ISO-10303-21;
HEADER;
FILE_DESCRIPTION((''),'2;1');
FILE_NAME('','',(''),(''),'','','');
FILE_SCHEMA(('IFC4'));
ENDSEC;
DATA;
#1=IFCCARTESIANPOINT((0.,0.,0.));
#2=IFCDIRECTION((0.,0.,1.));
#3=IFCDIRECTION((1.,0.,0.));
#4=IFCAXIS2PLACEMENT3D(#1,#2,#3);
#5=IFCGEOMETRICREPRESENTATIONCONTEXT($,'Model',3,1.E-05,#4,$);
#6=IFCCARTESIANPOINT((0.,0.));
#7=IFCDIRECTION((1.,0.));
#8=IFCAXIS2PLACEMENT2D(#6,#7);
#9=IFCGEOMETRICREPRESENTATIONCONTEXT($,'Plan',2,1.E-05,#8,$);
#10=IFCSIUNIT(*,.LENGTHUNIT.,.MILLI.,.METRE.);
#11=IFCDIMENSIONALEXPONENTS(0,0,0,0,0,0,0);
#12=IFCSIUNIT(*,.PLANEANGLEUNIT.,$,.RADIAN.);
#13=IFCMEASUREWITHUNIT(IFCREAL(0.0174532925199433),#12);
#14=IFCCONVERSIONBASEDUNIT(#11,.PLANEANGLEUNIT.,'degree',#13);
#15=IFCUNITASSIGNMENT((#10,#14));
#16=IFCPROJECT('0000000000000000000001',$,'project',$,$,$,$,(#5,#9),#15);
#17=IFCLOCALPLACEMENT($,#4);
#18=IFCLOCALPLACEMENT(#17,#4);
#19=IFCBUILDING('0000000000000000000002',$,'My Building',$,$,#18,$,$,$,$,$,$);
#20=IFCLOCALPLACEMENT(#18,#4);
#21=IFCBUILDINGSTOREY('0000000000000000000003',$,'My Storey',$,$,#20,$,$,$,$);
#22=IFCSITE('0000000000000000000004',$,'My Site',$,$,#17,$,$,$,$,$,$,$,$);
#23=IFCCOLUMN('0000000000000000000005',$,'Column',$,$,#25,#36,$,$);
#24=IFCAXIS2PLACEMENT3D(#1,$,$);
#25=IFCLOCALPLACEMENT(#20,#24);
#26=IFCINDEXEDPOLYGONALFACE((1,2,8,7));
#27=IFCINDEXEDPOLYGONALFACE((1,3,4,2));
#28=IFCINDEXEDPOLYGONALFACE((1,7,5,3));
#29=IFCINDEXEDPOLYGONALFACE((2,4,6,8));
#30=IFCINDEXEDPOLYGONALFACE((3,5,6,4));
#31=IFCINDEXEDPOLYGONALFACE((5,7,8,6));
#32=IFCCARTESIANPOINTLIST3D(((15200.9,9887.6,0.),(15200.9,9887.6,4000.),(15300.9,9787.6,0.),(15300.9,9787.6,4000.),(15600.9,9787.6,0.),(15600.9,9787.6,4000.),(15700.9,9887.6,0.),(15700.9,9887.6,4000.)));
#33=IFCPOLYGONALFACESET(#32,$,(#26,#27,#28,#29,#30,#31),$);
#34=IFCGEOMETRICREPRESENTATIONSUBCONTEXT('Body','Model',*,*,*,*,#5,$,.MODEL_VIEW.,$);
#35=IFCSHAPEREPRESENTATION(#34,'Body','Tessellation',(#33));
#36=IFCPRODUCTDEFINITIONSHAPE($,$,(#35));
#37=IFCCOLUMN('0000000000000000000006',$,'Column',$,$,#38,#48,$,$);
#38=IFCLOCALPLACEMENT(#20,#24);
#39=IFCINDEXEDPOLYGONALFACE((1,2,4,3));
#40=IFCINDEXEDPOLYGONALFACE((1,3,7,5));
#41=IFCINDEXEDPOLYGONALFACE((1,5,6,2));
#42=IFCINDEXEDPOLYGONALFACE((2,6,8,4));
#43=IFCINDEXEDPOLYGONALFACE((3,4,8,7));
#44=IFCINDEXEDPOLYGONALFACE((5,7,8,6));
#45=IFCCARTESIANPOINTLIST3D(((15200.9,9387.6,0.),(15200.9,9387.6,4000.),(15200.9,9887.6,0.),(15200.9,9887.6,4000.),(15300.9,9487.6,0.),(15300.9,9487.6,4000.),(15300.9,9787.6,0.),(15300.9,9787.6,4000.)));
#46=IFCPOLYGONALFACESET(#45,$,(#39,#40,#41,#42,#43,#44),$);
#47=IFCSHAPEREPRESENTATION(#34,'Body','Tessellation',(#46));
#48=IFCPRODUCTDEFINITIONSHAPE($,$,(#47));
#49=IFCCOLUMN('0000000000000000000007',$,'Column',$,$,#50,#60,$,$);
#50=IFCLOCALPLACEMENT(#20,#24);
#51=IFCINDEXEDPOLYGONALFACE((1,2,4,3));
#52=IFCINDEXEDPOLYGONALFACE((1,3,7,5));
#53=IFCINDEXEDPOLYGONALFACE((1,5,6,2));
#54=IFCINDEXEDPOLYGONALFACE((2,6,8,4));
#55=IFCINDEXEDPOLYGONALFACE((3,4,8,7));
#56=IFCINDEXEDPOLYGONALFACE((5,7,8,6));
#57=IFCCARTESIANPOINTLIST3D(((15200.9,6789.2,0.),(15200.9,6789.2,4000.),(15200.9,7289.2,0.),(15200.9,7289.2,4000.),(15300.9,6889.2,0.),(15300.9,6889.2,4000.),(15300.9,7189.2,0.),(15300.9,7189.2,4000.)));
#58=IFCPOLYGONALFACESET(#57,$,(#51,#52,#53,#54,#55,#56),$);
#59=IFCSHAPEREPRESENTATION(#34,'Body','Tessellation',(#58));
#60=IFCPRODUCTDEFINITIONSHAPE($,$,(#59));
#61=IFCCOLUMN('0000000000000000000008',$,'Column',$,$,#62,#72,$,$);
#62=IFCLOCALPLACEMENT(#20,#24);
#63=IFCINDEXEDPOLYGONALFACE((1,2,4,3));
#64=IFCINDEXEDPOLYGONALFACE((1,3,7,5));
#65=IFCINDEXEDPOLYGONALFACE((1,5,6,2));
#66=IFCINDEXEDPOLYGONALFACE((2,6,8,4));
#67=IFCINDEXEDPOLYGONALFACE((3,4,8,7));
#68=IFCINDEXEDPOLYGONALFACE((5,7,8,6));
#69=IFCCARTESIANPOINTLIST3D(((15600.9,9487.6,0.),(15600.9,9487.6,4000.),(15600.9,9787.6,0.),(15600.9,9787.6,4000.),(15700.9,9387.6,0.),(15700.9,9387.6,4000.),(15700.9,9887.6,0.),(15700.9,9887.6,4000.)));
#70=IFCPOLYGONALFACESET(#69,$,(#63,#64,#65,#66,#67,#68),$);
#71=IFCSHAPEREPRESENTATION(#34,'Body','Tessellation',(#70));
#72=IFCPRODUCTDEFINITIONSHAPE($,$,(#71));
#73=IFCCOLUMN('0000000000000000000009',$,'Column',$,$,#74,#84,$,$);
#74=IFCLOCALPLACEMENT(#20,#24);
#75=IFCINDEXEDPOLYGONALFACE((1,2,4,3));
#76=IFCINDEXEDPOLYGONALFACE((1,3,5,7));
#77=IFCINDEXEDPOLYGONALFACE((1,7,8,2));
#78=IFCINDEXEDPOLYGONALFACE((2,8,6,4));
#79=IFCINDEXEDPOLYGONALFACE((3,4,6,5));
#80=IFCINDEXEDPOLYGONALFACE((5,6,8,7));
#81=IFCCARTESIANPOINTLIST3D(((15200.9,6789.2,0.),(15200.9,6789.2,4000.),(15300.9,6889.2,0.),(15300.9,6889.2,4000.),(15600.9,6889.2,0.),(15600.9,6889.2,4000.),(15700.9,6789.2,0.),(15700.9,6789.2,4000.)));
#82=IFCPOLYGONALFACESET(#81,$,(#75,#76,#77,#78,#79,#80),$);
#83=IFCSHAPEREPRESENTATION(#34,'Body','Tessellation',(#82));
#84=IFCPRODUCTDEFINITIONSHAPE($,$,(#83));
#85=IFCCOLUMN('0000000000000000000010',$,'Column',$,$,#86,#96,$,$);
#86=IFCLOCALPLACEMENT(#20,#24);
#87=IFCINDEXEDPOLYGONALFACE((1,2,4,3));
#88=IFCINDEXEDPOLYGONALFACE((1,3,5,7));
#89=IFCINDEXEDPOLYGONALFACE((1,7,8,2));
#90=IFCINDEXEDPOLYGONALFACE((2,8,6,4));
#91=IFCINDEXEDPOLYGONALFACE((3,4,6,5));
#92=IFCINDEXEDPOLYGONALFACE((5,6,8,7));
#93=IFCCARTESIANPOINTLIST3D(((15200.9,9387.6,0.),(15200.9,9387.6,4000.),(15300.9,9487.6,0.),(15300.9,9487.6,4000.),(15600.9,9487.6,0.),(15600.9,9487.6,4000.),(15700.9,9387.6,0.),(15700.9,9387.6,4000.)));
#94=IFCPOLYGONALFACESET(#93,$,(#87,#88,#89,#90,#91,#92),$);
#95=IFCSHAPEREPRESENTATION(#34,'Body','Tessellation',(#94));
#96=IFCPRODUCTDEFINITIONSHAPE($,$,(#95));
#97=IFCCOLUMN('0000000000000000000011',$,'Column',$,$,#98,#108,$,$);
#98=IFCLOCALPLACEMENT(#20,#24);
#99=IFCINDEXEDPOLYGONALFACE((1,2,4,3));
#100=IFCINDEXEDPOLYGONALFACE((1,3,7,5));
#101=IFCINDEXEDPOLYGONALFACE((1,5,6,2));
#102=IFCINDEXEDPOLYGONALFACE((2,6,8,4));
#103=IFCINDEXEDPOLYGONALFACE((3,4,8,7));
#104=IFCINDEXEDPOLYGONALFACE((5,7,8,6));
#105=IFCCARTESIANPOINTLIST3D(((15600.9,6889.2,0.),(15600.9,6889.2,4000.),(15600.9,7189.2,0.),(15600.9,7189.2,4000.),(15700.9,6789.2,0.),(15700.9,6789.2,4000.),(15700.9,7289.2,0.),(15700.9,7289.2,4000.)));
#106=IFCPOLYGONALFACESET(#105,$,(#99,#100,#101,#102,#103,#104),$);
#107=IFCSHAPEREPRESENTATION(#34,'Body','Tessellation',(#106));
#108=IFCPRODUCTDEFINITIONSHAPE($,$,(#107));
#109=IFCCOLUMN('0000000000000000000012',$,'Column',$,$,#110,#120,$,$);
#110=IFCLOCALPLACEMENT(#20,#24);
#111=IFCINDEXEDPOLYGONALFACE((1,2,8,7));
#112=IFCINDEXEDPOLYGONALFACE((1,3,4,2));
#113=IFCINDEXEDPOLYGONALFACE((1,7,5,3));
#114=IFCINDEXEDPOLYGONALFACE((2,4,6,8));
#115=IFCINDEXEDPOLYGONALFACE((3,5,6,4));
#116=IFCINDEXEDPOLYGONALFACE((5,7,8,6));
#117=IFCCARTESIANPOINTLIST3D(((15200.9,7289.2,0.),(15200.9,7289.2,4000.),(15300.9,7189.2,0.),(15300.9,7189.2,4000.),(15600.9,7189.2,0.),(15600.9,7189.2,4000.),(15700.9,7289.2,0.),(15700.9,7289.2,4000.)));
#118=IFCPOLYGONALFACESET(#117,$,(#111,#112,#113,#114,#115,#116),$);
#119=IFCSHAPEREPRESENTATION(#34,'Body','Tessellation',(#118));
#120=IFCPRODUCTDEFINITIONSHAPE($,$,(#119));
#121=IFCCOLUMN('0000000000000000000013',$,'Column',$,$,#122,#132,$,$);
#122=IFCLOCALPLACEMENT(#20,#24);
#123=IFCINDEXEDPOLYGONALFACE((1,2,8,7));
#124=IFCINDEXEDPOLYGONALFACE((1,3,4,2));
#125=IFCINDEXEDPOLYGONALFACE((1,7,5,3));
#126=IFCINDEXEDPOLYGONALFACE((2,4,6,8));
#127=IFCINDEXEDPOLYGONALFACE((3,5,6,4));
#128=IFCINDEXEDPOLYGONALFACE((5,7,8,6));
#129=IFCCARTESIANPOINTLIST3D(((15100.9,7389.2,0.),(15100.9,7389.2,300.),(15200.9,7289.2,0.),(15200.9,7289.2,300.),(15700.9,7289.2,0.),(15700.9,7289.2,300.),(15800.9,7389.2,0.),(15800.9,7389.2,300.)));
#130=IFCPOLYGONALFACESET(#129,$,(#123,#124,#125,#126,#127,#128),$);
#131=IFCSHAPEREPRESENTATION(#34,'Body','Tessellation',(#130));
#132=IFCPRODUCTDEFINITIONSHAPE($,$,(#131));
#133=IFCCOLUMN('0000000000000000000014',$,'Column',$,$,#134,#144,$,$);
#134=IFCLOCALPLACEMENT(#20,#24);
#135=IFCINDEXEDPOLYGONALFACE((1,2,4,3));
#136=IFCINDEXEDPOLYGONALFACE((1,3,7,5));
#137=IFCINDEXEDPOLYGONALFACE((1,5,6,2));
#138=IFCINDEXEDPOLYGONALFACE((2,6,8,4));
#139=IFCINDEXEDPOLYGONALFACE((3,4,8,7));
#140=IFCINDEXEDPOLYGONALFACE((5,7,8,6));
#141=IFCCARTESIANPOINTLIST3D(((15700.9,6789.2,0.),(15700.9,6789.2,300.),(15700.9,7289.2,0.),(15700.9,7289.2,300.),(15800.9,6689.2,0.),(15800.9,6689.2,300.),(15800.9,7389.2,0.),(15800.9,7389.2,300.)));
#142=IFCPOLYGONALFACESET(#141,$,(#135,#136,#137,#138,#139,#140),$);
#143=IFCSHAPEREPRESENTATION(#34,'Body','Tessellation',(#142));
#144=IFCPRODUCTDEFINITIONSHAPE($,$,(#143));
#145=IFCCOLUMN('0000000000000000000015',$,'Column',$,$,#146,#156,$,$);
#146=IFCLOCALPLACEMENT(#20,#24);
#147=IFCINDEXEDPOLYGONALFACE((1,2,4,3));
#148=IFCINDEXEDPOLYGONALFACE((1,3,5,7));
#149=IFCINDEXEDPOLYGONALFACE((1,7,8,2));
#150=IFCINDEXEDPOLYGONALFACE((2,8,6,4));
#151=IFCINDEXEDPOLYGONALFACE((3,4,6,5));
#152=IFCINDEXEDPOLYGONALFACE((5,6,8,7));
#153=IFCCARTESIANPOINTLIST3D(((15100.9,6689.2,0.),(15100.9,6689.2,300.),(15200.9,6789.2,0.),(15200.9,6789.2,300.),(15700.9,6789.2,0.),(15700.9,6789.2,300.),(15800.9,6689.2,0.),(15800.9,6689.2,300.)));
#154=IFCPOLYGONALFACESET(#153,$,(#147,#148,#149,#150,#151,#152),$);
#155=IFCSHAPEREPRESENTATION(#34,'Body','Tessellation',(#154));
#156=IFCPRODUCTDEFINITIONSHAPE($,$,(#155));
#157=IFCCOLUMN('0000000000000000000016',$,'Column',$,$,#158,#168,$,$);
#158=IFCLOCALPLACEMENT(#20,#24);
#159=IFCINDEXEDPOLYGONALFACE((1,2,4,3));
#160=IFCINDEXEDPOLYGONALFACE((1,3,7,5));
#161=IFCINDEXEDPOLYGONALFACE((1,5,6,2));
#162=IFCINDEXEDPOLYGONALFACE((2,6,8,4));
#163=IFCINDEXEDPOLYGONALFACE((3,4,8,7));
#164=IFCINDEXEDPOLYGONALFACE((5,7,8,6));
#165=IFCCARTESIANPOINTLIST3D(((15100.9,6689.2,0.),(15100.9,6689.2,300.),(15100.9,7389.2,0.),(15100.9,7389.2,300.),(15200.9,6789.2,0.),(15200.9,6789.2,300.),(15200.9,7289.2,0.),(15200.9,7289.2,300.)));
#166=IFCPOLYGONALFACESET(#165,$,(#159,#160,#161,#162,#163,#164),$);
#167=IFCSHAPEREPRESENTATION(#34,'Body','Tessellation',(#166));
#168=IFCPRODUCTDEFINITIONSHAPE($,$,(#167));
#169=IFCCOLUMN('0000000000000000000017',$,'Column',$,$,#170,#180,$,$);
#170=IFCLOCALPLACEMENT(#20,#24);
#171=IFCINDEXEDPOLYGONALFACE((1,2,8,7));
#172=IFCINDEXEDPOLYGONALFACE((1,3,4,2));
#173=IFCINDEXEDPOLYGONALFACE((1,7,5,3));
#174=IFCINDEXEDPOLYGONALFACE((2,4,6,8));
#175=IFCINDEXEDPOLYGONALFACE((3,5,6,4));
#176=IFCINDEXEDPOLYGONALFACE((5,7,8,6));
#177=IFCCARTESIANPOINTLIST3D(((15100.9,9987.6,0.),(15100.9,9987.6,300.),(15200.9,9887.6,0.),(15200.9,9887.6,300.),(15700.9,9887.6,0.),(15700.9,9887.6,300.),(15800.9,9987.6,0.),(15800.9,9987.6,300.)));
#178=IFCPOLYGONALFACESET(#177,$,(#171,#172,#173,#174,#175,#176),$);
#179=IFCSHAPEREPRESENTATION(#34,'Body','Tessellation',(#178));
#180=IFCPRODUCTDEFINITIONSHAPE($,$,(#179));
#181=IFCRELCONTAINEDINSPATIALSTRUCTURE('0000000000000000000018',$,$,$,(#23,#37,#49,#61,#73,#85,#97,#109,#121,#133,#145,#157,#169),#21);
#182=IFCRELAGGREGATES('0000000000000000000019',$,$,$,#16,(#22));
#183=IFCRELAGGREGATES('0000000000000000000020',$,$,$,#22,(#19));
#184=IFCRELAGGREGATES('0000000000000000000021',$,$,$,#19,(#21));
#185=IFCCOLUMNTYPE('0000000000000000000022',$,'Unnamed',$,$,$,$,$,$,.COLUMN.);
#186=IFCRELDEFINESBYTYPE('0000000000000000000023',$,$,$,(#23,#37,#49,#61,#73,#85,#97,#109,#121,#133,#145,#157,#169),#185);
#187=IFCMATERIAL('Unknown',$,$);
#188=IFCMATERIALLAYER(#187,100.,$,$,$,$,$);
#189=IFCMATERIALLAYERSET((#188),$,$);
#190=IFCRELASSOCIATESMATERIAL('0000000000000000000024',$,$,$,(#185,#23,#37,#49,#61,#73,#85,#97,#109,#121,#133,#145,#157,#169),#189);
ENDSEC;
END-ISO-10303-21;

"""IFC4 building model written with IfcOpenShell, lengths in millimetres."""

from ifc_helpers import new_model, entity, si_unit, converted_unit, frame, origin_with_axes, origin_2d_with_axis, place, context, subcontext, project, spatial, line, indexed_curve, outline, extrude, material, layer, layer_set, layer_usage, type_object, element, save


model = new_model("IFC4")

# Units and contexts
model_context = context("Model", 3, precision=1e-05, world=origin_with_axes())
plan_context = context("Plan", 2, precision=1e-05, world=origin_2d_with_axis())
body_context = subcontext(model_context, "Body", "Model", "MODEL_VIEW")
ifc_project = project(units=[si_unit("LENGTHUNIT", "METRE", prefix="MILLI"), converted_unit("PLANEANGLEUNIT", "degree", entity("IfcReal", 0.0174532925199433), si_unit("PLANEANGLEUNIT", "RADIAN"), dimensions=[0, 0, 0, 0, 0, 0, 0])], contexts=[model_context, plan_context])

# Site, building, storey
site_placement = place(None, origin_with_axes())
site = spatial("IfcSite", under=ifc_project, at=site_placement, Name="My Site")
building_placement = place(site_placement, origin_with_axes())
building = spatial("IfcBuilding", under=site, at=building_placement, Name="My Building")
storey_placement = place(building_placement, origin_with_axes())
storey = spatial("IfcBuildingStorey", under=building, at=storey_placement, Name="My Storey")

# Columns
ifc_material = material(Name="Unknown")
ifc_layer_1 = layer(ifc_material, 100.0)
ifc_layer_set_1 = layer_set([ifc_layer_1])
ifc_layer_usage_1 = layer_usage(ifc_layer_set_1, "AXIS2", "POSITIVE", 0.0)
column_type = type_object("IfcColumnType", Name="Unnamed", PredefinedType="COLUMN", material=ifc_layer_set_1)
column_1_placement = place(storey_placement, frame((15300.9, 9787.6, 0.0), z_axis=(0.0, 0.0, 1.0), x_axis=(1.0, 0.0, 0.0)))
element("IfcColumn", 1, at=column_1_placement, inside=storey, type_object=column_type, material=ifc_layer_usage_1, Name="Column", context=body_context, shape_type="SweptSolid", body=[
    extrude(outline(indexed_curve([(0.0, 0.0), (-100.0, 100.0), (400.0, 100.0), (300.0, 0.0)], segments=[line(1, 2, 3, 4, 1)])), origin_with_axes(), (0.0, 0.0, 1.0), 4000.0),
])
ifc_layer_usage_2 = layer_usage(ifc_layer_set_1, "AXIS2", "POSITIVE", 0.0)
column_2_placement = place(storey_placement, frame((15300.9, 9487.6, 0.0), z_axis=(0.0, 0.0, 1.0), x_axis=(0.0, 1.0, 0.0)))
element("IfcColumn", 2, at=column_2_placement, inside=storey, type_object=column_type, material=ifc_layer_usage_2, Name="Column", context=body_context, shape_type="SweptSolid", body=[
    extrude(outline(indexed_curve([(0.0, 0.0), (-100.0, 100.0), (400.0, 100.0), (300.0, 0.0)], segments=[line(1, 2, 3, 4, 1)])), origin_with_axes(), (0.0, 0.0, 1.0), 4000.0),
])
ifc_layer_usage_3 = layer_usage(ifc_layer_set_1, "AXIS2", "POSITIVE", 0.0)
column_3_placement = place(storey_placement, frame((15300.9, 6889.2, 0.0), z_axis=(0.0, 0.0, 1.0), x_axis=(0.0, 1.0, 0.0)))
element("IfcColumn", 3, at=column_3_placement, inside=storey, type_object=column_type, material=ifc_layer_usage_3, Name="Column", context=body_context, shape_type="SweptSolid", body=[
    extrude(outline(indexed_curve([(0.0, 0.0), (-100.0, 100.0), (400.0, 100.0), (300.0, 0.0)], segments=[line(1, 2, 3, 4, 1)])), origin_with_axes(), (0.0, 0.0, 1.0), 4000.0),
])
ifc_layer_usage_4 = layer_usage(ifc_layer_set_1, "AXIS2", "POSITIVE", 0.0)
column_4_placement = place(storey_placement, frame((15600.9, 9787.6, 0.0), z_axis=(0.0, 0.0, 1.0), x_axis=(0.0, -1.0, 0.0)))
element("IfcColumn", 4, at=column_4_placement, inside=storey, type_object=column_type, material=ifc_layer_usage_4, Name="Column", context=body_context, shape_type="SweptSolid", body=[
    extrude(outline(indexed_curve([(0.0, 0.0), (-100.0, 100.0), (400.0, 100.0), (300.0, 0.0)], segments=[line(1, 2, 3, 4, 1)])), origin_with_axes(), (0.0, 0.0, 1.0), 4000.0),
])
ifc_layer_usage_5 = layer_usage(ifc_layer_set_1, "AXIS2", "POSITIVE", 0.0)
column_5_placement = place(storey_placement, frame((15600.9, 6889.2, 0.0), z_axis=(0.0, 0.0, 1.0), x_axis=(-1.0, 0.0, 0.0)))
element("IfcColumn", 5, at=column_5_placement, inside=storey, type_object=column_type, material=ifc_layer_usage_5, Name="Column", context=body_context, shape_type="SweptSolid", body=[
    extrude(outline(indexed_curve([(0.0, 0.0), (-100.0, 100.0), (400.0, 100.0), (300.0, 0.0)], segments=[line(1, 2, 3, 4, 1)])), origin_with_axes(), (0.0, 0.0, 1.0), 4000.0),
])
ifc_layer_usage_6 = layer_usage(ifc_layer_set_1, "AXIS2", "POSITIVE", 0.0)
column_6_placement = place(storey_placement, frame((15600.9, 9487.6, 0.0), z_axis=(0.0, 0.0, 1.0), x_axis=(-1.0, 0.0, 0.0)))
element("IfcColumn", 6, at=column_6_placement, inside=storey, type_object=column_type, material=ifc_layer_usage_6, Name="Column", context=body_context, shape_type="SweptSolid", body=[
    extrude(outline(indexed_curve([(0.0, 0.0), (-100.0, 100.0), (400.0, 100.0), (300.0, 0.0)], segments=[line(1, 2, 3, 4, 1)])), origin_with_axes(), (0.0, 0.0, 1.0), 4000.0),
])
ifc_layer_usage_7 = layer_usage(ifc_layer_set_1, "AXIS2", "POSITIVE", 0.0)
column_7_placement = place(storey_placement, frame((15600.9, 7189.2, 0.0), z_axis=(0.0, 0.0, 1.0), x_axis=(0.0, -1.0, 0.0)))
element("IfcColumn", 7, at=column_7_placement, inside=storey, type_object=column_type, material=ifc_layer_usage_7, Name="Column", context=body_context, shape_type="SweptSolid", body=[
    extrude(outline(indexed_curve([(0.0, 0.0), (-100.0, 100.0), (400.0, 100.0), (300.0, 0.0)], segments=[line(1, 2, 3, 4, 1)])), origin_with_axes(), (0.0, 0.0, 1.0), 4000.0),
])
ifc_layer_usage_8 = layer_usage(ifc_layer_set_1, "AXIS2", "POSITIVE", 0.0)
column_8_placement = place(storey_placement, frame((15300.9, 7189.2, 0.0), z_axis=(0.0, 0.0, 1.0), x_axis=(1.0, 0.0, 0.0)))
element("IfcColumn", 8, at=column_8_placement, inside=storey, type_object=column_type, material=ifc_layer_usage_8, Name="Column", context=body_context, shape_type="SweptSolid", body=[
    extrude(outline(indexed_curve([(0.0, 0.0), (-100.0, 100.0), (400.0, 100.0), (300.0, 0.0)], segments=[line(1, 2, 3, 4, 1)])), origin_with_axes(), (0.0, 0.0, 1.0), 4000.0),
])
ifc_layer_usage_9 = layer_usage(ifc_layer_set_1, "AXIS2", "POSITIVE", 0.0)
column_9_placement = place(storey_placement, frame((15200.9, 7289.2, 0.0), z_axis=(0.0, 0.0, 1.0), x_axis=(1.0, 0.0, 0.0)))
element("IfcColumn", 9, at=column_9_placement, inside=storey, type_object=column_type, material=ifc_layer_usage_9, Name="Column", context=body_context, shape_type="SweptSolid", body=[
    extrude(outline(indexed_curve([(0.0, 0.0), (-100.0, 100.0), (600.0, 100.0), (500.0, 0.0)], segments=[line(1, 2, 3, 4, 1)])), origin_with_axes(), (0.0, 0.0, 1.0), 300.0),
])
ifc_layer_usage_10 = layer_usage(ifc_layer_set_1, "AXIS2", "POSITIVE", 0.0)
column_10_placement = place(storey_placement, frame((15700.9, 7289.2, 0.0), z_axis=(0.0, 0.0, 1.0), x_axis=(0.0, -1.0, 0.0)))
element("IfcColumn", 10, at=column_10_placement, inside=storey, type_object=column_type, material=ifc_layer_usage_10, Name="Column", context=body_context, shape_type="SweptSolid", body=[
    extrude(outline(indexed_curve([(0.0, 0.0), (-100.0, 100.0), (600.0, 100.0), (500.0, 0.0)], segments=[line(1, 2, 3, 4, 1)])), origin_with_axes(), (0.0, 0.0, 1.0), 300.0),
])
ifc_layer_usage_11 = layer_usage(ifc_layer_set_1, "AXIS2", "POSITIVE", 0.0)
column_11_placement = place(storey_placement, frame((15700.9, 6789.2, 0.0), z_axis=(0.0, 0.0, 1.0), x_axis=(-1.0, 0.0, 0.0)))
element("IfcColumn", 11, at=column_11_placement, inside=storey, type_object=column_type, material=ifc_layer_usage_11, Name="Column", context=body_context, shape_type="SweptSolid", body=[
    extrude(outline(indexed_curve([(0.0, 0.0), (-100.0, 100.0), (600.0, 100.0), (500.0, 0.0)], segments=[line(1, 2, 3, 4, 1)])), origin_with_axes(), (0.0, 0.0, 1.0), 300.0),
])
ifc_layer_usage_12 = layer_usage(ifc_layer_set_1, "AXIS2", "POSITIVE", 0.0)
column_12_placement = place(storey_placement, frame((15200.9, 6789.2, 0.0), z_axis=(0.0, 0.0, 1.0), x_axis=(0.0, 1.0, 0.0)))
element("IfcColumn", 12, at=column_12_placement, inside=storey, type_object=column_type, material=ifc_layer_usage_12, Name="Column", context=body_context, shape_type="SweptSolid", body=[
    extrude(outline(indexed_curve([(0.0, 0.0), (-100.0, 100.0), (600.0, 100.0), (500.0, 0.0)], segments=[line(1, 2, 3, 4, 1)])), origin_with_axes(), (0.0, 0.0, 1.0), 300.0),
])
ifc_layer_usage_13 = layer_usage(ifc_layer_set_1, "AXIS2", "POSITIVE", 0.0)
column_13_placement = place(storey_placement, frame((15200.9, 9887.6, 0.0), z_axis=(0.0, 0.0, 1.0), x_axis=(1.0, 0.0, 0.0)))
element("IfcColumn", 13, at=column_13_placement, inside=storey, type_object=column_type, material=ifc_layer_usage_13, Name="Column", context=body_context, shape_type="SweptSolid", body=[
    extrude(outline(indexed_curve([(0.0, 0.0), (-100.0, 100.0), (600.0, 100.0), (500.0, 0.0)], segments=[line(1, 2, 3, 4, 1)])), origin_with_axes(), (0.0, 0.0, 1.0), 300.0),
])

save(model, "model.ifc")
